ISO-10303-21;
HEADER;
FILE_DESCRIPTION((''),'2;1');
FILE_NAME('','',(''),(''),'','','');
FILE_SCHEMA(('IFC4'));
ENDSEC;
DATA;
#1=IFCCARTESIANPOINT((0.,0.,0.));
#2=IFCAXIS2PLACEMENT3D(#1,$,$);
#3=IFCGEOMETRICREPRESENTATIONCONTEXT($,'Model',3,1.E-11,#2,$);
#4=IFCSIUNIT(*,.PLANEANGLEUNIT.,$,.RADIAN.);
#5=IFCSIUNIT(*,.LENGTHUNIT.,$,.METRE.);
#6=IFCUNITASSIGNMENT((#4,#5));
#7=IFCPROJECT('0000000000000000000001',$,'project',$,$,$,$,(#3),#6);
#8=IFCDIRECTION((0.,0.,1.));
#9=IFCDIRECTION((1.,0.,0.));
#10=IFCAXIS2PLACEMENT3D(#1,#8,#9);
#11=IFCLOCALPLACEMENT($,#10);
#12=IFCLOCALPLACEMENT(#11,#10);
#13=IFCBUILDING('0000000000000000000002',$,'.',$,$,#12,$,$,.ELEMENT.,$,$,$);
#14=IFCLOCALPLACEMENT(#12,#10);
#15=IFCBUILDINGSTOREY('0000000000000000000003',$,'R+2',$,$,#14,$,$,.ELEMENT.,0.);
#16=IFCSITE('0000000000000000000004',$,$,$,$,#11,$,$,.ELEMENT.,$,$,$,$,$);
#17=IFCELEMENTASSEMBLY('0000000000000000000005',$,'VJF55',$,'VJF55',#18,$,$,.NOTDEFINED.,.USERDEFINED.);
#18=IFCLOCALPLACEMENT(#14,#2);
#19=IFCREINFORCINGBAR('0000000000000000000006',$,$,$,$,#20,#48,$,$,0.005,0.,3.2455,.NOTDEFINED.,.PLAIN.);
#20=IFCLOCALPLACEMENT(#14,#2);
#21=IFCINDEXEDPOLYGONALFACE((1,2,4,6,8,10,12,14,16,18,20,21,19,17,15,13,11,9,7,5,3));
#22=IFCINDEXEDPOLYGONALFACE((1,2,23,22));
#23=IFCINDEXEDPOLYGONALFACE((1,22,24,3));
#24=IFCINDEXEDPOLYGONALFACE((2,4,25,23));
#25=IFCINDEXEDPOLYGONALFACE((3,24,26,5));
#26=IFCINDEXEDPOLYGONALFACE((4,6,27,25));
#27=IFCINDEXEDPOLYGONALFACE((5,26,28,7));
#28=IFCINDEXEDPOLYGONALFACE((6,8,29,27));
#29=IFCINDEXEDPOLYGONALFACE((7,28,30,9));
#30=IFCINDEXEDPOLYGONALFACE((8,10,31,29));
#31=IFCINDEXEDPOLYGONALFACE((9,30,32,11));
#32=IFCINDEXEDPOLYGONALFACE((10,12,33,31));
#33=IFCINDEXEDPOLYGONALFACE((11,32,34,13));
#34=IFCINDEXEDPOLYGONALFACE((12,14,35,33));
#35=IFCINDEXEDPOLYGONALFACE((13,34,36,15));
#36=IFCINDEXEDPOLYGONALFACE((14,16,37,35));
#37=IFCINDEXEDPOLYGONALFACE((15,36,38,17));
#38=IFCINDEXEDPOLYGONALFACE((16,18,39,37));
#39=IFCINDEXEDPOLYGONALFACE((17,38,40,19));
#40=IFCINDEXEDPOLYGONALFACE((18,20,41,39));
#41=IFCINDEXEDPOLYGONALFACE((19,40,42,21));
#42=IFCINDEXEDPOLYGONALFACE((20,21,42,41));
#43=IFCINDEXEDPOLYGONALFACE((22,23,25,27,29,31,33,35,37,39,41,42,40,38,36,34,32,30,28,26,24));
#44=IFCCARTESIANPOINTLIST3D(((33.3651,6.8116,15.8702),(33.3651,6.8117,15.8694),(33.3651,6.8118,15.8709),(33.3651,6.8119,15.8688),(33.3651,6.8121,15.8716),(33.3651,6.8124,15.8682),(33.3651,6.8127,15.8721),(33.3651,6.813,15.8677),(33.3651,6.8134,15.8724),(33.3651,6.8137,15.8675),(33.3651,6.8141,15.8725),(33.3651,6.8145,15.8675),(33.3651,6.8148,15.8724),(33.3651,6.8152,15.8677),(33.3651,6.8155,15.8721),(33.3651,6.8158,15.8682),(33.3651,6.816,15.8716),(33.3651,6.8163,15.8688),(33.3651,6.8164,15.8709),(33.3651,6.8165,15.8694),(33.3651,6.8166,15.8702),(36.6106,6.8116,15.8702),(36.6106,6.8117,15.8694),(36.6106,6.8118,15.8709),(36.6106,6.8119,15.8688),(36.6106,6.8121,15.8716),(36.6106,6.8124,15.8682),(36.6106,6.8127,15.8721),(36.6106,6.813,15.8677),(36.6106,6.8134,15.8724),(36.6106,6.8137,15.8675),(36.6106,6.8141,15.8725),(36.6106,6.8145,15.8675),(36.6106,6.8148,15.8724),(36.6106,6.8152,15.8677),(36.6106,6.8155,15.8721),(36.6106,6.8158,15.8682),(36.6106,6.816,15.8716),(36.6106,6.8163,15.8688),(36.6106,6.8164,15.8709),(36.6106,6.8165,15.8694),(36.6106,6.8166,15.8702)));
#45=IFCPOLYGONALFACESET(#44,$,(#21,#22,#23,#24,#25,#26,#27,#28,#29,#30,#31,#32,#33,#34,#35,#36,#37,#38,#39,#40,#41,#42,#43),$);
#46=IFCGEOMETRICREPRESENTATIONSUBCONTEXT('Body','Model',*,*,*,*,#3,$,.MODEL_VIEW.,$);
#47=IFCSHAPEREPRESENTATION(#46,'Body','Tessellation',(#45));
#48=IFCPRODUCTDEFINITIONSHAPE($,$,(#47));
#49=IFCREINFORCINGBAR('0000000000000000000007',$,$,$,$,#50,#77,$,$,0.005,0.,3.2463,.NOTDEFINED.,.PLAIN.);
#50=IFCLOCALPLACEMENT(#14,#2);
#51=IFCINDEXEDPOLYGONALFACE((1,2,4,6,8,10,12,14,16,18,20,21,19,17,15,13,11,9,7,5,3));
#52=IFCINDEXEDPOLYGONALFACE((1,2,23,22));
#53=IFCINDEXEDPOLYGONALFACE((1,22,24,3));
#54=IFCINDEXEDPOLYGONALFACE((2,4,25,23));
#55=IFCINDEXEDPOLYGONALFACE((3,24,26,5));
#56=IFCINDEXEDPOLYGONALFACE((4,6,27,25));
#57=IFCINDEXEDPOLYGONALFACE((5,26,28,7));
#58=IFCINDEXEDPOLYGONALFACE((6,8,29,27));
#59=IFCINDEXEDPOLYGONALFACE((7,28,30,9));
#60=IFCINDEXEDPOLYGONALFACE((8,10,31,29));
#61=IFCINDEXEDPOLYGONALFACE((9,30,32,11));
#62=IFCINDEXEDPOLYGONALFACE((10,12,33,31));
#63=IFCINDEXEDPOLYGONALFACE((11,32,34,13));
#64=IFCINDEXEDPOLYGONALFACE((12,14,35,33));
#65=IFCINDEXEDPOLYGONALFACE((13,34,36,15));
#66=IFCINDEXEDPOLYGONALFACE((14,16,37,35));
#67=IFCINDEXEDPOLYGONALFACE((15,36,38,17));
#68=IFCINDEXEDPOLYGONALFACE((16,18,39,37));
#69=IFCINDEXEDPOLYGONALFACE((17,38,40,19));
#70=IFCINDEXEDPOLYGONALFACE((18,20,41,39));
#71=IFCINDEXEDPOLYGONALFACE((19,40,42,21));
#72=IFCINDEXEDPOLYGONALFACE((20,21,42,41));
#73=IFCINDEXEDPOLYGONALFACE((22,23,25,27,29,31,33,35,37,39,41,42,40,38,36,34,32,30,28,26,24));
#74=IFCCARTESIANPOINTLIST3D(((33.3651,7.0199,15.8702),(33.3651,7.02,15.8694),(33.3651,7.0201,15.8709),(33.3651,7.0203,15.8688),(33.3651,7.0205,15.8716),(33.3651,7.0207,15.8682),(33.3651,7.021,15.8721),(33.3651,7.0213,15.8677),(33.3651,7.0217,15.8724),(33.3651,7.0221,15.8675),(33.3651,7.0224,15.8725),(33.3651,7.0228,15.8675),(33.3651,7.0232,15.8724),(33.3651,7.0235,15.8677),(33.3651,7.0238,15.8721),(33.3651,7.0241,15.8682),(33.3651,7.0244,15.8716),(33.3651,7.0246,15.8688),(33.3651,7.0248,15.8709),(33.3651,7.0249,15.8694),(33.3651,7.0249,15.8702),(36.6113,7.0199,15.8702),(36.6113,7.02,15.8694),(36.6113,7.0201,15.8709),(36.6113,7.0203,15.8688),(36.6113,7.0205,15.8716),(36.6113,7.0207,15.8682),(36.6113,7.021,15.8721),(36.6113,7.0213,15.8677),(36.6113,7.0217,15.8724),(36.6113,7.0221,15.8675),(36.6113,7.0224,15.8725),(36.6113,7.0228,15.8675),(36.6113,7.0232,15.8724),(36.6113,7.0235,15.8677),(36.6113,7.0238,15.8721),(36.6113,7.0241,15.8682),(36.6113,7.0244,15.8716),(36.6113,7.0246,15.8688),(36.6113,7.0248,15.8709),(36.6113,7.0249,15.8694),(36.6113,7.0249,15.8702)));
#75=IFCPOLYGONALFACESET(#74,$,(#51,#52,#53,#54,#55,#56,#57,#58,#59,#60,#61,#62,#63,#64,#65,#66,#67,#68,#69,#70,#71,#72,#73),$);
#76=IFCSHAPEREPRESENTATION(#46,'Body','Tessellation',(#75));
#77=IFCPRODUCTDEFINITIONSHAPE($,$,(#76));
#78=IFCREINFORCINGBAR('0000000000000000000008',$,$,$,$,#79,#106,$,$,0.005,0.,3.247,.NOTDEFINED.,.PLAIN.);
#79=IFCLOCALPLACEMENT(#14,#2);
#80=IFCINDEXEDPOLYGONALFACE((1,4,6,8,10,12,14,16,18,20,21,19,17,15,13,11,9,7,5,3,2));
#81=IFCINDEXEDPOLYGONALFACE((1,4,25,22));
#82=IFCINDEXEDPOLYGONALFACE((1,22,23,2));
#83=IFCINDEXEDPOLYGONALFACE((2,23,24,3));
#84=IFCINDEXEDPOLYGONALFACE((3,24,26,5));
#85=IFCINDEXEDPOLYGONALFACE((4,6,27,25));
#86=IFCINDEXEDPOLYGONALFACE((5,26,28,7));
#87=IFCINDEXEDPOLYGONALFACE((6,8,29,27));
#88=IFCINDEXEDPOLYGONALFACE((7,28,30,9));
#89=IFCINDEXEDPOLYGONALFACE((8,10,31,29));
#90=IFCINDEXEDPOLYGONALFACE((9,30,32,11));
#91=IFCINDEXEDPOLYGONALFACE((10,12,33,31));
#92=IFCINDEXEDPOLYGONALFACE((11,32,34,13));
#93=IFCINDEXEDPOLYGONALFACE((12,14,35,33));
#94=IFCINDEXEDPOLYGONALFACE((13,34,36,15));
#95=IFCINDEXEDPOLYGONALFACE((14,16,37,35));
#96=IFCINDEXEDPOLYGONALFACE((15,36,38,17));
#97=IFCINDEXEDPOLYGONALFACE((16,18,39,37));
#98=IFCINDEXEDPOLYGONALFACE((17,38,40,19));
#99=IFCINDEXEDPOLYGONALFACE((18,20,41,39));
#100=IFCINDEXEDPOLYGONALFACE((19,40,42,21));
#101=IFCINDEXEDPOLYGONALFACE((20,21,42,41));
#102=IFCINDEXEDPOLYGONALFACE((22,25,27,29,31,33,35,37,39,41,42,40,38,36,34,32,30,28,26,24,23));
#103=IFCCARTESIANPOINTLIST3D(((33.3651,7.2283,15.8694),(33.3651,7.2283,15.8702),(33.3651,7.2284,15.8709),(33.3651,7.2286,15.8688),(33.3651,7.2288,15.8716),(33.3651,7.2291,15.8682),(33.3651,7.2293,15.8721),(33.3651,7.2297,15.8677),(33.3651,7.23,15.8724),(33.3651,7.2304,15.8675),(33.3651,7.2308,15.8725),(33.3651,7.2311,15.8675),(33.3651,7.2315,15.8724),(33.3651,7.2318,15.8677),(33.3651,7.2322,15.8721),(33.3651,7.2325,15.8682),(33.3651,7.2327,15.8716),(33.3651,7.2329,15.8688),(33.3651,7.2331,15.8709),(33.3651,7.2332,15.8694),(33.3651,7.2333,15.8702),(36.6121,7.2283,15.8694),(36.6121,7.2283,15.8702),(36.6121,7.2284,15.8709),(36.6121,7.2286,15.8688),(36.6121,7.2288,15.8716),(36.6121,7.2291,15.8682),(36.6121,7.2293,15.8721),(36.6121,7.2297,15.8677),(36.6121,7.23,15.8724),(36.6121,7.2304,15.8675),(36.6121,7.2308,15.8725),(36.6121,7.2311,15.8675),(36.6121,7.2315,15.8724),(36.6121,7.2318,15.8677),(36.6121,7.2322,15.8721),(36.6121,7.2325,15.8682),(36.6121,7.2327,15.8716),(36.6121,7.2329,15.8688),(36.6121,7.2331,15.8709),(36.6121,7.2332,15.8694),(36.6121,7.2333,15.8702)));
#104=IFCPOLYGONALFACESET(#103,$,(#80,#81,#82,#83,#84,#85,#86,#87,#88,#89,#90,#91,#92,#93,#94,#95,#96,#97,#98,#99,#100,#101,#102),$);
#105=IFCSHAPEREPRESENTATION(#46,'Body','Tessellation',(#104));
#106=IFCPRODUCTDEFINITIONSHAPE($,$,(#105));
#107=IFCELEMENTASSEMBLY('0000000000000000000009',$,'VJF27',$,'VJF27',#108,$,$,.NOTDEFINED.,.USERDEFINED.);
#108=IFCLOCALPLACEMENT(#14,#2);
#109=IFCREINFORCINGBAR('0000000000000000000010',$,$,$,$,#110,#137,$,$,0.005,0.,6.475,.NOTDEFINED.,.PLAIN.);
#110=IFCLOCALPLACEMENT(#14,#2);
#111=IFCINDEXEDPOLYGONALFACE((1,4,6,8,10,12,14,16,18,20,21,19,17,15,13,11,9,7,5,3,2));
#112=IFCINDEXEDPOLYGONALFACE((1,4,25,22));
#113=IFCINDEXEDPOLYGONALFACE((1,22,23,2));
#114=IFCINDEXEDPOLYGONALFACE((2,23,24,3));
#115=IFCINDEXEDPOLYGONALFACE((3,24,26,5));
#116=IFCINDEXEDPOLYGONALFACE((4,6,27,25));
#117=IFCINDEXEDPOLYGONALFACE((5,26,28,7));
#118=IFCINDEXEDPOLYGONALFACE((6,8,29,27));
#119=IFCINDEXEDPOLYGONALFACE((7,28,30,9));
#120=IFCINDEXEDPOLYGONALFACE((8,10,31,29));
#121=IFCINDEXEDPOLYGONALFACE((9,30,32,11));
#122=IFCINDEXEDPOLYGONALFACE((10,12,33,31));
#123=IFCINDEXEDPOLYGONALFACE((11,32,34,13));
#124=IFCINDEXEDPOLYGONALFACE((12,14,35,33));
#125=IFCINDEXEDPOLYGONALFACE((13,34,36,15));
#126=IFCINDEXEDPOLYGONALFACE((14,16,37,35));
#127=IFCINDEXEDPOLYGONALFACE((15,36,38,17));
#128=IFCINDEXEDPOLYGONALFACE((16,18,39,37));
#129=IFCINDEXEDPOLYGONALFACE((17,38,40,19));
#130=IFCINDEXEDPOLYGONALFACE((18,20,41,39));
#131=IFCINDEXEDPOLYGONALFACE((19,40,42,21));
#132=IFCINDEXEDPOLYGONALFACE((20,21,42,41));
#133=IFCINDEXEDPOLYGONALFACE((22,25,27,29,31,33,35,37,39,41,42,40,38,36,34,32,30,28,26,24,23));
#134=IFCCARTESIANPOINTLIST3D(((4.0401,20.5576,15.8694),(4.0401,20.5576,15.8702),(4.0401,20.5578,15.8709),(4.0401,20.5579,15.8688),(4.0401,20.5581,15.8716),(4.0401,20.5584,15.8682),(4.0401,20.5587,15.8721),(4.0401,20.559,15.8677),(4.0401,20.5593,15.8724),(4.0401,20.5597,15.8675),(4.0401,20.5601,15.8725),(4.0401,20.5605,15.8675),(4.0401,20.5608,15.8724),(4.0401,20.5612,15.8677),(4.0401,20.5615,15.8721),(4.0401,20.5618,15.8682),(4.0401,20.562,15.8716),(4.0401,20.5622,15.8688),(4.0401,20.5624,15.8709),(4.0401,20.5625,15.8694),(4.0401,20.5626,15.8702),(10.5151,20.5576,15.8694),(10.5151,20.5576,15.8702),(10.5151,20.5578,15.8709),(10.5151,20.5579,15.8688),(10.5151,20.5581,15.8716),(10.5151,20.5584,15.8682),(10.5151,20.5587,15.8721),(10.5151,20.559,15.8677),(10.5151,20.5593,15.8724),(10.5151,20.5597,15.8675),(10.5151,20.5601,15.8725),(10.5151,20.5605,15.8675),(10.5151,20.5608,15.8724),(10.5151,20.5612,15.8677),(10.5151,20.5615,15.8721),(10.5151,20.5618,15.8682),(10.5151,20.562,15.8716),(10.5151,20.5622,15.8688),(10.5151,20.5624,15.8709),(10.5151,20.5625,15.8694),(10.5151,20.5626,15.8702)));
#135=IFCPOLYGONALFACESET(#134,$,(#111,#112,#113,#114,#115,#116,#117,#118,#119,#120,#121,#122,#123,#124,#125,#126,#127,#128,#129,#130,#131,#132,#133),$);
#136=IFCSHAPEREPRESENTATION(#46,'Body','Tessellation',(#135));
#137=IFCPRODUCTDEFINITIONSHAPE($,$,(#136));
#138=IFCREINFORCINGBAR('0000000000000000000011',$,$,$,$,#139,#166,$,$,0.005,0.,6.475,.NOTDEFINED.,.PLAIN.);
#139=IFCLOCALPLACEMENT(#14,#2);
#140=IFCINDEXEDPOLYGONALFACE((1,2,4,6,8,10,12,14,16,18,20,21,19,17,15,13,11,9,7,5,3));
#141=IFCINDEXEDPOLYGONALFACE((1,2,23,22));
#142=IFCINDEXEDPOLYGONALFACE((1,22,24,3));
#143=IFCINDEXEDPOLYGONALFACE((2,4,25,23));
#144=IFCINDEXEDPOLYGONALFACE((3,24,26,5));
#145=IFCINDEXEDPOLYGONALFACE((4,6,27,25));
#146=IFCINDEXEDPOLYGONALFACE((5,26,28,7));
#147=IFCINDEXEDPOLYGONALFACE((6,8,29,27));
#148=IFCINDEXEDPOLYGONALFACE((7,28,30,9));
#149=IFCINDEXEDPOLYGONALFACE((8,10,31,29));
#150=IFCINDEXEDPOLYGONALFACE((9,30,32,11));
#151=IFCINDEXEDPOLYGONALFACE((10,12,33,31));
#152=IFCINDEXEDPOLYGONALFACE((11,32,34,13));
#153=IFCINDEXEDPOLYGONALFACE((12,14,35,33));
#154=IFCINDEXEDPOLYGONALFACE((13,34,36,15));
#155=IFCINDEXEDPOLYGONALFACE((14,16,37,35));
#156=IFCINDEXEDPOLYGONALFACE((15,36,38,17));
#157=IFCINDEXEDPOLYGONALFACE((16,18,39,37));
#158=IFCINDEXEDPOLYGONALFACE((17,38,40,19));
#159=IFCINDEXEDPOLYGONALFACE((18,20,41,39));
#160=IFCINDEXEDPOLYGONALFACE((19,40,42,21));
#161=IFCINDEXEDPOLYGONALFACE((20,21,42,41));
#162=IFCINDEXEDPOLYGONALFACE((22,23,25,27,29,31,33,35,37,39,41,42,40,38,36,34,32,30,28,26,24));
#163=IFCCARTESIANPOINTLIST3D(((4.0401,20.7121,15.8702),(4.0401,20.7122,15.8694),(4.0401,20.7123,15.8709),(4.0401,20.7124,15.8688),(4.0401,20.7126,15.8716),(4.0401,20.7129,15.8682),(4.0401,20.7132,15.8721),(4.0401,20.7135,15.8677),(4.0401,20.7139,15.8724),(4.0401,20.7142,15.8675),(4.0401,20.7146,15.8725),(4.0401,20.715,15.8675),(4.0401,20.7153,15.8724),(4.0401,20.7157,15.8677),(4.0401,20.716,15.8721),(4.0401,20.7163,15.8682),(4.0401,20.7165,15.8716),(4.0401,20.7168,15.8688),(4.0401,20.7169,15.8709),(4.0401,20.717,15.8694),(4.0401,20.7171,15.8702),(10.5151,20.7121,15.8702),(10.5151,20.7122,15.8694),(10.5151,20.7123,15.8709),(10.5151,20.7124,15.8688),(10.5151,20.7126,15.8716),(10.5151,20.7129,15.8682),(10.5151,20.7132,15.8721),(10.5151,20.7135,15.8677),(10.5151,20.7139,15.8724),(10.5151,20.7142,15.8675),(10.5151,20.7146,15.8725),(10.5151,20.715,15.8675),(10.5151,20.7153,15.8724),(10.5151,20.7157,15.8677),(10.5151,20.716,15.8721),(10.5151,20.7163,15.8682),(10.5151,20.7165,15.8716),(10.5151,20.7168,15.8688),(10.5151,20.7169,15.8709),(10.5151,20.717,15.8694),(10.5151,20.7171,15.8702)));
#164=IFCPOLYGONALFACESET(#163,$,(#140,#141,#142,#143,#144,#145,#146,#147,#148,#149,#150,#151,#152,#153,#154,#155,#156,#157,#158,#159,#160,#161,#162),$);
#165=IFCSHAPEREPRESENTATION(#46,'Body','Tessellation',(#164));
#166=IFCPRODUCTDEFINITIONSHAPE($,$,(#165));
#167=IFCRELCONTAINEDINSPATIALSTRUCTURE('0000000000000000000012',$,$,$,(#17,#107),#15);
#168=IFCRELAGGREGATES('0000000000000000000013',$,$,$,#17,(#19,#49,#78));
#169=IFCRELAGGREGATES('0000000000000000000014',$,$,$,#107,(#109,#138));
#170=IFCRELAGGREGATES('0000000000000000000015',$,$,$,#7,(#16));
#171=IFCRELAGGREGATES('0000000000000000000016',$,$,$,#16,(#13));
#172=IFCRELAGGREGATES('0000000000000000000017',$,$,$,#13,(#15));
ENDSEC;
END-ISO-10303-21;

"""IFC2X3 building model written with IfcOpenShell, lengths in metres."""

from ifc_helpers import new_model, entity, si_unit, origin, origin_with_axes, place, context, subcontext, project, spatial, shape, element, aggregate, save


model = new_model("IFC2X3")

# Units and contexts
model_context = context("Model", 3, precision=1e-11, world=origin())
body_context = subcontext(model_context, "Body", "Model", "MODEL_VIEW")
ifc_project = project(units=[si_unit("PLANEANGLEUNIT", "RADIAN"), si_unit("LENGTHUNIT", "METRE")], contexts=[model_context])

# Site, building, storey
site_placement = place(None, origin_with_axes())
site = spatial("IfcSite", under=ifc_project, at=site_placement, CompositionType="ELEMENT")
building_placement = place(site_placement, origin_with_axes())
building = spatial("IfcBuilding", under=site, at=building_placement, Name=".", CompositionType="ELEMENT")
storey_placement = place(building_placement, origin_with_axes())
storey = spatial("IfcBuildingStorey", under=building, at=storey_placement, Name="R+2", CompositionType="ELEMENT", Elevation=0.0)

# Element assemblies, reinforcing bars
assembly_1_placement = place(storey_placement, origin_with_axes())
assembly_1 = element("IfcElementAssembly", 1, at=assembly_1_placement, inside=storey, Name="VJF55", ObjectType="VJF55", AssemblyPlace="NOTDEFINED", PredefinedType="USERDEFINED")
reinforcing_bar_1_placement = place(assembly_1_placement, origin_with_axes())
reinforcing_bar_1 = element("IfcReinforcingBar", 2, at=reinforcing_bar_1_placement, BarLength=3.2455, BarRole="NOTDEFINED", BarSurface="PLAIN", CrossSectionArea=0.0, NominalDiameter=0.005, shapes=[
    shape(body_context, "Body", "AdvancedSweptSolid", [entity("IfcSweptDiskSolid", entity("IfcPolyline", [entity("IfcCartesianPoint", [33.3651, 6.8141, 15.87]), entity("IfcCartesianPoint", [36.6106, 6.8141, 15.87])]), 0.0025, None, 0.0, 3.2455)]),
    shape(body_context, "Body", "AdvancedSweptSolid", [entity("IfcSweptDiskSolid", entity("IfcPolyline", [entity("IfcCartesianPoint", [33.3651, 6.8141, 15.87]), entity("IfcCartesianPoint", [36.6106, 6.8141, 15.87])]), 0.0025, None, 0.0, 3.2455)]),
])
reinforcing_bar_2_placement = place(assembly_1_placement, origin_with_axes())
reinforcing_bar_2 = element("IfcReinforcingBar", 3, at=reinforcing_bar_2_placement, BarLength=3.2463, BarRole="NOTDEFINED", BarSurface="PLAIN", CrossSectionArea=0.0, NominalDiameter=0.005, shapes=[
    shape(body_context, "Body", "AdvancedSweptSolid", [entity("IfcSweptDiskSolid", entity("IfcPolyline", [entity("IfcCartesianPoint", [33.3651, 7.0224, 15.87]), entity("IfcCartesianPoint", [36.6113, 7.0224, 15.87])]), 0.0025, None, 0.0, 3.2463)]),
    shape(body_context, "Body", "AdvancedSweptSolid", [entity("IfcSweptDiskSolid", entity("IfcPolyline", [entity("IfcCartesianPoint", [33.3651, 7.0224, 15.87]), entity("IfcCartesianPoint", [36.6113, 7.0224, 15.87])]), 0.0025, None, 0.0, 3.2463)]),
])
reinforcing_bar_3_placement = place(assembly_1_placement, origin_with_axes())
reinforcing_bar_3 = element("IfcReinforcingBar", 4, at=reinforcing_bar_3_placement, BarLength=3.247, BarRole="NOTDEFINED", BarSurface="PLAIN", CrossSectionArea=0.0, NominalDiameter=0.005, shapes=[
    shape(body_context, "Body", "AdvancedSweptSolid", [entity("IfcSweptDiskSolid", entity("IfcPolyline", [entity("IfcCartesianPoint", [33.3651, 7.2308, 15.87]), entity("IfcCartesianPoint", [36.6121, 7.2308, 15.87])]), 0.0025, None, 0.0, 3.247)]),
    shape(body_context, "Body", "AdvancedSweptSolid", [entity("IfcSweptDiskSolid", entity("IfcPolyline", [entity("IfcCartesianPoint", [33.3651, 7.2308, 15.87]), entity("IfcCartesianPoint", [36.6121, 7.2308, 15.87])]), 0.0025, None, 0.0, 3.247)]),
])
aggregate(assembly_1, [reinforcing_bar_1, reinforcing_bar_2, reinforcing_bar_3])
assembly_2_placement = place(storey_placement, origin_with_axes())
assembly_2 = element("IfcElementAssembly", 5, at=assembly_2_placement, inside=storey, Name="VJF27", ObjectType="VJF27", AssemblyPlace="NOTDEFINED", PredefinedType="USERDEFINED")
reinforcing_bar_4_placement = place(assembly_2_placement, origin_with_axes())
reinforcing_bar_4 = element("IfcReinforcingBar", 6, at=reinforcing_bar_4_placement, BarLength=6.475, BarRole="NOTDEFINED", BarSurface="PLAIN", CrossSectionArea=0.0, NominalDiameter=0.005, shapes=[
    shape(body_context, "Body", "AdvancedSweptSolid", [entity("IfcSweptDiskSolid", entity("IfcPolyline", [entity("IfcCartesianPoint", [4.0401, 20.5601, 15.87]), entity("IfcCartesianPoint", [10.5151, 20.5601, 15.87])]), 0.0025, None, 0.0, 6.475)]),
    shape(body_context, "Body", "AdvancedSweptSolid", [entity("IfcSweptDiskSolid", entity("IfcPolyline", [entity("IfcCartesianPoint", [4.0401, 20.5601, 15.87]), entity("IfcCartesianPoint", [10.5151, 20.5601, 15.87])]), 0.0025, None, 0.0, 6.475)]),
])
reinforcing_bar_5_placement = place(assembly_2_placement, origin_with_axes())
reinforcing_bar_5 = element("IfcReinforcingBar", 7, at=reinforcing_bar_5_placement, BarLength=6.475, BarRole="NOTDEFINED", BarSurface="PLAIN", CrossSectionArea=0.0, NominalDiameter=0.005, shapes=[
    shape(body_context, "Body", "AdvancedSweptSolid", [entity("IfcSweptDiskSolid", entity("IfcPolyline", [entity("IfcCartesianPoint", [4.0401, 20.7146, 15.87]), entity("IfcCartesianPoint", [10.5151, 20.7146, 15.87])]), 0.0025, None, 0.0, 6.475)]),
    shape(body_context, "Body", "AdvancedSweptSolid", [entity("IfcSweptDiskSolid", entity("IfcPolyline", [entity("IfcCartesianPoint", [4.0401, 20.7146, 15.87]), entity("IfcCartesianPoint", [10.5151, 20.7146, 15.87])]), 0.0025, None, 0.0, 6.475)]),
])
aggregate(assembly_2, [reinforcing_bar_4, reinforcing_bar_5])

save(model, "model.ifc")
